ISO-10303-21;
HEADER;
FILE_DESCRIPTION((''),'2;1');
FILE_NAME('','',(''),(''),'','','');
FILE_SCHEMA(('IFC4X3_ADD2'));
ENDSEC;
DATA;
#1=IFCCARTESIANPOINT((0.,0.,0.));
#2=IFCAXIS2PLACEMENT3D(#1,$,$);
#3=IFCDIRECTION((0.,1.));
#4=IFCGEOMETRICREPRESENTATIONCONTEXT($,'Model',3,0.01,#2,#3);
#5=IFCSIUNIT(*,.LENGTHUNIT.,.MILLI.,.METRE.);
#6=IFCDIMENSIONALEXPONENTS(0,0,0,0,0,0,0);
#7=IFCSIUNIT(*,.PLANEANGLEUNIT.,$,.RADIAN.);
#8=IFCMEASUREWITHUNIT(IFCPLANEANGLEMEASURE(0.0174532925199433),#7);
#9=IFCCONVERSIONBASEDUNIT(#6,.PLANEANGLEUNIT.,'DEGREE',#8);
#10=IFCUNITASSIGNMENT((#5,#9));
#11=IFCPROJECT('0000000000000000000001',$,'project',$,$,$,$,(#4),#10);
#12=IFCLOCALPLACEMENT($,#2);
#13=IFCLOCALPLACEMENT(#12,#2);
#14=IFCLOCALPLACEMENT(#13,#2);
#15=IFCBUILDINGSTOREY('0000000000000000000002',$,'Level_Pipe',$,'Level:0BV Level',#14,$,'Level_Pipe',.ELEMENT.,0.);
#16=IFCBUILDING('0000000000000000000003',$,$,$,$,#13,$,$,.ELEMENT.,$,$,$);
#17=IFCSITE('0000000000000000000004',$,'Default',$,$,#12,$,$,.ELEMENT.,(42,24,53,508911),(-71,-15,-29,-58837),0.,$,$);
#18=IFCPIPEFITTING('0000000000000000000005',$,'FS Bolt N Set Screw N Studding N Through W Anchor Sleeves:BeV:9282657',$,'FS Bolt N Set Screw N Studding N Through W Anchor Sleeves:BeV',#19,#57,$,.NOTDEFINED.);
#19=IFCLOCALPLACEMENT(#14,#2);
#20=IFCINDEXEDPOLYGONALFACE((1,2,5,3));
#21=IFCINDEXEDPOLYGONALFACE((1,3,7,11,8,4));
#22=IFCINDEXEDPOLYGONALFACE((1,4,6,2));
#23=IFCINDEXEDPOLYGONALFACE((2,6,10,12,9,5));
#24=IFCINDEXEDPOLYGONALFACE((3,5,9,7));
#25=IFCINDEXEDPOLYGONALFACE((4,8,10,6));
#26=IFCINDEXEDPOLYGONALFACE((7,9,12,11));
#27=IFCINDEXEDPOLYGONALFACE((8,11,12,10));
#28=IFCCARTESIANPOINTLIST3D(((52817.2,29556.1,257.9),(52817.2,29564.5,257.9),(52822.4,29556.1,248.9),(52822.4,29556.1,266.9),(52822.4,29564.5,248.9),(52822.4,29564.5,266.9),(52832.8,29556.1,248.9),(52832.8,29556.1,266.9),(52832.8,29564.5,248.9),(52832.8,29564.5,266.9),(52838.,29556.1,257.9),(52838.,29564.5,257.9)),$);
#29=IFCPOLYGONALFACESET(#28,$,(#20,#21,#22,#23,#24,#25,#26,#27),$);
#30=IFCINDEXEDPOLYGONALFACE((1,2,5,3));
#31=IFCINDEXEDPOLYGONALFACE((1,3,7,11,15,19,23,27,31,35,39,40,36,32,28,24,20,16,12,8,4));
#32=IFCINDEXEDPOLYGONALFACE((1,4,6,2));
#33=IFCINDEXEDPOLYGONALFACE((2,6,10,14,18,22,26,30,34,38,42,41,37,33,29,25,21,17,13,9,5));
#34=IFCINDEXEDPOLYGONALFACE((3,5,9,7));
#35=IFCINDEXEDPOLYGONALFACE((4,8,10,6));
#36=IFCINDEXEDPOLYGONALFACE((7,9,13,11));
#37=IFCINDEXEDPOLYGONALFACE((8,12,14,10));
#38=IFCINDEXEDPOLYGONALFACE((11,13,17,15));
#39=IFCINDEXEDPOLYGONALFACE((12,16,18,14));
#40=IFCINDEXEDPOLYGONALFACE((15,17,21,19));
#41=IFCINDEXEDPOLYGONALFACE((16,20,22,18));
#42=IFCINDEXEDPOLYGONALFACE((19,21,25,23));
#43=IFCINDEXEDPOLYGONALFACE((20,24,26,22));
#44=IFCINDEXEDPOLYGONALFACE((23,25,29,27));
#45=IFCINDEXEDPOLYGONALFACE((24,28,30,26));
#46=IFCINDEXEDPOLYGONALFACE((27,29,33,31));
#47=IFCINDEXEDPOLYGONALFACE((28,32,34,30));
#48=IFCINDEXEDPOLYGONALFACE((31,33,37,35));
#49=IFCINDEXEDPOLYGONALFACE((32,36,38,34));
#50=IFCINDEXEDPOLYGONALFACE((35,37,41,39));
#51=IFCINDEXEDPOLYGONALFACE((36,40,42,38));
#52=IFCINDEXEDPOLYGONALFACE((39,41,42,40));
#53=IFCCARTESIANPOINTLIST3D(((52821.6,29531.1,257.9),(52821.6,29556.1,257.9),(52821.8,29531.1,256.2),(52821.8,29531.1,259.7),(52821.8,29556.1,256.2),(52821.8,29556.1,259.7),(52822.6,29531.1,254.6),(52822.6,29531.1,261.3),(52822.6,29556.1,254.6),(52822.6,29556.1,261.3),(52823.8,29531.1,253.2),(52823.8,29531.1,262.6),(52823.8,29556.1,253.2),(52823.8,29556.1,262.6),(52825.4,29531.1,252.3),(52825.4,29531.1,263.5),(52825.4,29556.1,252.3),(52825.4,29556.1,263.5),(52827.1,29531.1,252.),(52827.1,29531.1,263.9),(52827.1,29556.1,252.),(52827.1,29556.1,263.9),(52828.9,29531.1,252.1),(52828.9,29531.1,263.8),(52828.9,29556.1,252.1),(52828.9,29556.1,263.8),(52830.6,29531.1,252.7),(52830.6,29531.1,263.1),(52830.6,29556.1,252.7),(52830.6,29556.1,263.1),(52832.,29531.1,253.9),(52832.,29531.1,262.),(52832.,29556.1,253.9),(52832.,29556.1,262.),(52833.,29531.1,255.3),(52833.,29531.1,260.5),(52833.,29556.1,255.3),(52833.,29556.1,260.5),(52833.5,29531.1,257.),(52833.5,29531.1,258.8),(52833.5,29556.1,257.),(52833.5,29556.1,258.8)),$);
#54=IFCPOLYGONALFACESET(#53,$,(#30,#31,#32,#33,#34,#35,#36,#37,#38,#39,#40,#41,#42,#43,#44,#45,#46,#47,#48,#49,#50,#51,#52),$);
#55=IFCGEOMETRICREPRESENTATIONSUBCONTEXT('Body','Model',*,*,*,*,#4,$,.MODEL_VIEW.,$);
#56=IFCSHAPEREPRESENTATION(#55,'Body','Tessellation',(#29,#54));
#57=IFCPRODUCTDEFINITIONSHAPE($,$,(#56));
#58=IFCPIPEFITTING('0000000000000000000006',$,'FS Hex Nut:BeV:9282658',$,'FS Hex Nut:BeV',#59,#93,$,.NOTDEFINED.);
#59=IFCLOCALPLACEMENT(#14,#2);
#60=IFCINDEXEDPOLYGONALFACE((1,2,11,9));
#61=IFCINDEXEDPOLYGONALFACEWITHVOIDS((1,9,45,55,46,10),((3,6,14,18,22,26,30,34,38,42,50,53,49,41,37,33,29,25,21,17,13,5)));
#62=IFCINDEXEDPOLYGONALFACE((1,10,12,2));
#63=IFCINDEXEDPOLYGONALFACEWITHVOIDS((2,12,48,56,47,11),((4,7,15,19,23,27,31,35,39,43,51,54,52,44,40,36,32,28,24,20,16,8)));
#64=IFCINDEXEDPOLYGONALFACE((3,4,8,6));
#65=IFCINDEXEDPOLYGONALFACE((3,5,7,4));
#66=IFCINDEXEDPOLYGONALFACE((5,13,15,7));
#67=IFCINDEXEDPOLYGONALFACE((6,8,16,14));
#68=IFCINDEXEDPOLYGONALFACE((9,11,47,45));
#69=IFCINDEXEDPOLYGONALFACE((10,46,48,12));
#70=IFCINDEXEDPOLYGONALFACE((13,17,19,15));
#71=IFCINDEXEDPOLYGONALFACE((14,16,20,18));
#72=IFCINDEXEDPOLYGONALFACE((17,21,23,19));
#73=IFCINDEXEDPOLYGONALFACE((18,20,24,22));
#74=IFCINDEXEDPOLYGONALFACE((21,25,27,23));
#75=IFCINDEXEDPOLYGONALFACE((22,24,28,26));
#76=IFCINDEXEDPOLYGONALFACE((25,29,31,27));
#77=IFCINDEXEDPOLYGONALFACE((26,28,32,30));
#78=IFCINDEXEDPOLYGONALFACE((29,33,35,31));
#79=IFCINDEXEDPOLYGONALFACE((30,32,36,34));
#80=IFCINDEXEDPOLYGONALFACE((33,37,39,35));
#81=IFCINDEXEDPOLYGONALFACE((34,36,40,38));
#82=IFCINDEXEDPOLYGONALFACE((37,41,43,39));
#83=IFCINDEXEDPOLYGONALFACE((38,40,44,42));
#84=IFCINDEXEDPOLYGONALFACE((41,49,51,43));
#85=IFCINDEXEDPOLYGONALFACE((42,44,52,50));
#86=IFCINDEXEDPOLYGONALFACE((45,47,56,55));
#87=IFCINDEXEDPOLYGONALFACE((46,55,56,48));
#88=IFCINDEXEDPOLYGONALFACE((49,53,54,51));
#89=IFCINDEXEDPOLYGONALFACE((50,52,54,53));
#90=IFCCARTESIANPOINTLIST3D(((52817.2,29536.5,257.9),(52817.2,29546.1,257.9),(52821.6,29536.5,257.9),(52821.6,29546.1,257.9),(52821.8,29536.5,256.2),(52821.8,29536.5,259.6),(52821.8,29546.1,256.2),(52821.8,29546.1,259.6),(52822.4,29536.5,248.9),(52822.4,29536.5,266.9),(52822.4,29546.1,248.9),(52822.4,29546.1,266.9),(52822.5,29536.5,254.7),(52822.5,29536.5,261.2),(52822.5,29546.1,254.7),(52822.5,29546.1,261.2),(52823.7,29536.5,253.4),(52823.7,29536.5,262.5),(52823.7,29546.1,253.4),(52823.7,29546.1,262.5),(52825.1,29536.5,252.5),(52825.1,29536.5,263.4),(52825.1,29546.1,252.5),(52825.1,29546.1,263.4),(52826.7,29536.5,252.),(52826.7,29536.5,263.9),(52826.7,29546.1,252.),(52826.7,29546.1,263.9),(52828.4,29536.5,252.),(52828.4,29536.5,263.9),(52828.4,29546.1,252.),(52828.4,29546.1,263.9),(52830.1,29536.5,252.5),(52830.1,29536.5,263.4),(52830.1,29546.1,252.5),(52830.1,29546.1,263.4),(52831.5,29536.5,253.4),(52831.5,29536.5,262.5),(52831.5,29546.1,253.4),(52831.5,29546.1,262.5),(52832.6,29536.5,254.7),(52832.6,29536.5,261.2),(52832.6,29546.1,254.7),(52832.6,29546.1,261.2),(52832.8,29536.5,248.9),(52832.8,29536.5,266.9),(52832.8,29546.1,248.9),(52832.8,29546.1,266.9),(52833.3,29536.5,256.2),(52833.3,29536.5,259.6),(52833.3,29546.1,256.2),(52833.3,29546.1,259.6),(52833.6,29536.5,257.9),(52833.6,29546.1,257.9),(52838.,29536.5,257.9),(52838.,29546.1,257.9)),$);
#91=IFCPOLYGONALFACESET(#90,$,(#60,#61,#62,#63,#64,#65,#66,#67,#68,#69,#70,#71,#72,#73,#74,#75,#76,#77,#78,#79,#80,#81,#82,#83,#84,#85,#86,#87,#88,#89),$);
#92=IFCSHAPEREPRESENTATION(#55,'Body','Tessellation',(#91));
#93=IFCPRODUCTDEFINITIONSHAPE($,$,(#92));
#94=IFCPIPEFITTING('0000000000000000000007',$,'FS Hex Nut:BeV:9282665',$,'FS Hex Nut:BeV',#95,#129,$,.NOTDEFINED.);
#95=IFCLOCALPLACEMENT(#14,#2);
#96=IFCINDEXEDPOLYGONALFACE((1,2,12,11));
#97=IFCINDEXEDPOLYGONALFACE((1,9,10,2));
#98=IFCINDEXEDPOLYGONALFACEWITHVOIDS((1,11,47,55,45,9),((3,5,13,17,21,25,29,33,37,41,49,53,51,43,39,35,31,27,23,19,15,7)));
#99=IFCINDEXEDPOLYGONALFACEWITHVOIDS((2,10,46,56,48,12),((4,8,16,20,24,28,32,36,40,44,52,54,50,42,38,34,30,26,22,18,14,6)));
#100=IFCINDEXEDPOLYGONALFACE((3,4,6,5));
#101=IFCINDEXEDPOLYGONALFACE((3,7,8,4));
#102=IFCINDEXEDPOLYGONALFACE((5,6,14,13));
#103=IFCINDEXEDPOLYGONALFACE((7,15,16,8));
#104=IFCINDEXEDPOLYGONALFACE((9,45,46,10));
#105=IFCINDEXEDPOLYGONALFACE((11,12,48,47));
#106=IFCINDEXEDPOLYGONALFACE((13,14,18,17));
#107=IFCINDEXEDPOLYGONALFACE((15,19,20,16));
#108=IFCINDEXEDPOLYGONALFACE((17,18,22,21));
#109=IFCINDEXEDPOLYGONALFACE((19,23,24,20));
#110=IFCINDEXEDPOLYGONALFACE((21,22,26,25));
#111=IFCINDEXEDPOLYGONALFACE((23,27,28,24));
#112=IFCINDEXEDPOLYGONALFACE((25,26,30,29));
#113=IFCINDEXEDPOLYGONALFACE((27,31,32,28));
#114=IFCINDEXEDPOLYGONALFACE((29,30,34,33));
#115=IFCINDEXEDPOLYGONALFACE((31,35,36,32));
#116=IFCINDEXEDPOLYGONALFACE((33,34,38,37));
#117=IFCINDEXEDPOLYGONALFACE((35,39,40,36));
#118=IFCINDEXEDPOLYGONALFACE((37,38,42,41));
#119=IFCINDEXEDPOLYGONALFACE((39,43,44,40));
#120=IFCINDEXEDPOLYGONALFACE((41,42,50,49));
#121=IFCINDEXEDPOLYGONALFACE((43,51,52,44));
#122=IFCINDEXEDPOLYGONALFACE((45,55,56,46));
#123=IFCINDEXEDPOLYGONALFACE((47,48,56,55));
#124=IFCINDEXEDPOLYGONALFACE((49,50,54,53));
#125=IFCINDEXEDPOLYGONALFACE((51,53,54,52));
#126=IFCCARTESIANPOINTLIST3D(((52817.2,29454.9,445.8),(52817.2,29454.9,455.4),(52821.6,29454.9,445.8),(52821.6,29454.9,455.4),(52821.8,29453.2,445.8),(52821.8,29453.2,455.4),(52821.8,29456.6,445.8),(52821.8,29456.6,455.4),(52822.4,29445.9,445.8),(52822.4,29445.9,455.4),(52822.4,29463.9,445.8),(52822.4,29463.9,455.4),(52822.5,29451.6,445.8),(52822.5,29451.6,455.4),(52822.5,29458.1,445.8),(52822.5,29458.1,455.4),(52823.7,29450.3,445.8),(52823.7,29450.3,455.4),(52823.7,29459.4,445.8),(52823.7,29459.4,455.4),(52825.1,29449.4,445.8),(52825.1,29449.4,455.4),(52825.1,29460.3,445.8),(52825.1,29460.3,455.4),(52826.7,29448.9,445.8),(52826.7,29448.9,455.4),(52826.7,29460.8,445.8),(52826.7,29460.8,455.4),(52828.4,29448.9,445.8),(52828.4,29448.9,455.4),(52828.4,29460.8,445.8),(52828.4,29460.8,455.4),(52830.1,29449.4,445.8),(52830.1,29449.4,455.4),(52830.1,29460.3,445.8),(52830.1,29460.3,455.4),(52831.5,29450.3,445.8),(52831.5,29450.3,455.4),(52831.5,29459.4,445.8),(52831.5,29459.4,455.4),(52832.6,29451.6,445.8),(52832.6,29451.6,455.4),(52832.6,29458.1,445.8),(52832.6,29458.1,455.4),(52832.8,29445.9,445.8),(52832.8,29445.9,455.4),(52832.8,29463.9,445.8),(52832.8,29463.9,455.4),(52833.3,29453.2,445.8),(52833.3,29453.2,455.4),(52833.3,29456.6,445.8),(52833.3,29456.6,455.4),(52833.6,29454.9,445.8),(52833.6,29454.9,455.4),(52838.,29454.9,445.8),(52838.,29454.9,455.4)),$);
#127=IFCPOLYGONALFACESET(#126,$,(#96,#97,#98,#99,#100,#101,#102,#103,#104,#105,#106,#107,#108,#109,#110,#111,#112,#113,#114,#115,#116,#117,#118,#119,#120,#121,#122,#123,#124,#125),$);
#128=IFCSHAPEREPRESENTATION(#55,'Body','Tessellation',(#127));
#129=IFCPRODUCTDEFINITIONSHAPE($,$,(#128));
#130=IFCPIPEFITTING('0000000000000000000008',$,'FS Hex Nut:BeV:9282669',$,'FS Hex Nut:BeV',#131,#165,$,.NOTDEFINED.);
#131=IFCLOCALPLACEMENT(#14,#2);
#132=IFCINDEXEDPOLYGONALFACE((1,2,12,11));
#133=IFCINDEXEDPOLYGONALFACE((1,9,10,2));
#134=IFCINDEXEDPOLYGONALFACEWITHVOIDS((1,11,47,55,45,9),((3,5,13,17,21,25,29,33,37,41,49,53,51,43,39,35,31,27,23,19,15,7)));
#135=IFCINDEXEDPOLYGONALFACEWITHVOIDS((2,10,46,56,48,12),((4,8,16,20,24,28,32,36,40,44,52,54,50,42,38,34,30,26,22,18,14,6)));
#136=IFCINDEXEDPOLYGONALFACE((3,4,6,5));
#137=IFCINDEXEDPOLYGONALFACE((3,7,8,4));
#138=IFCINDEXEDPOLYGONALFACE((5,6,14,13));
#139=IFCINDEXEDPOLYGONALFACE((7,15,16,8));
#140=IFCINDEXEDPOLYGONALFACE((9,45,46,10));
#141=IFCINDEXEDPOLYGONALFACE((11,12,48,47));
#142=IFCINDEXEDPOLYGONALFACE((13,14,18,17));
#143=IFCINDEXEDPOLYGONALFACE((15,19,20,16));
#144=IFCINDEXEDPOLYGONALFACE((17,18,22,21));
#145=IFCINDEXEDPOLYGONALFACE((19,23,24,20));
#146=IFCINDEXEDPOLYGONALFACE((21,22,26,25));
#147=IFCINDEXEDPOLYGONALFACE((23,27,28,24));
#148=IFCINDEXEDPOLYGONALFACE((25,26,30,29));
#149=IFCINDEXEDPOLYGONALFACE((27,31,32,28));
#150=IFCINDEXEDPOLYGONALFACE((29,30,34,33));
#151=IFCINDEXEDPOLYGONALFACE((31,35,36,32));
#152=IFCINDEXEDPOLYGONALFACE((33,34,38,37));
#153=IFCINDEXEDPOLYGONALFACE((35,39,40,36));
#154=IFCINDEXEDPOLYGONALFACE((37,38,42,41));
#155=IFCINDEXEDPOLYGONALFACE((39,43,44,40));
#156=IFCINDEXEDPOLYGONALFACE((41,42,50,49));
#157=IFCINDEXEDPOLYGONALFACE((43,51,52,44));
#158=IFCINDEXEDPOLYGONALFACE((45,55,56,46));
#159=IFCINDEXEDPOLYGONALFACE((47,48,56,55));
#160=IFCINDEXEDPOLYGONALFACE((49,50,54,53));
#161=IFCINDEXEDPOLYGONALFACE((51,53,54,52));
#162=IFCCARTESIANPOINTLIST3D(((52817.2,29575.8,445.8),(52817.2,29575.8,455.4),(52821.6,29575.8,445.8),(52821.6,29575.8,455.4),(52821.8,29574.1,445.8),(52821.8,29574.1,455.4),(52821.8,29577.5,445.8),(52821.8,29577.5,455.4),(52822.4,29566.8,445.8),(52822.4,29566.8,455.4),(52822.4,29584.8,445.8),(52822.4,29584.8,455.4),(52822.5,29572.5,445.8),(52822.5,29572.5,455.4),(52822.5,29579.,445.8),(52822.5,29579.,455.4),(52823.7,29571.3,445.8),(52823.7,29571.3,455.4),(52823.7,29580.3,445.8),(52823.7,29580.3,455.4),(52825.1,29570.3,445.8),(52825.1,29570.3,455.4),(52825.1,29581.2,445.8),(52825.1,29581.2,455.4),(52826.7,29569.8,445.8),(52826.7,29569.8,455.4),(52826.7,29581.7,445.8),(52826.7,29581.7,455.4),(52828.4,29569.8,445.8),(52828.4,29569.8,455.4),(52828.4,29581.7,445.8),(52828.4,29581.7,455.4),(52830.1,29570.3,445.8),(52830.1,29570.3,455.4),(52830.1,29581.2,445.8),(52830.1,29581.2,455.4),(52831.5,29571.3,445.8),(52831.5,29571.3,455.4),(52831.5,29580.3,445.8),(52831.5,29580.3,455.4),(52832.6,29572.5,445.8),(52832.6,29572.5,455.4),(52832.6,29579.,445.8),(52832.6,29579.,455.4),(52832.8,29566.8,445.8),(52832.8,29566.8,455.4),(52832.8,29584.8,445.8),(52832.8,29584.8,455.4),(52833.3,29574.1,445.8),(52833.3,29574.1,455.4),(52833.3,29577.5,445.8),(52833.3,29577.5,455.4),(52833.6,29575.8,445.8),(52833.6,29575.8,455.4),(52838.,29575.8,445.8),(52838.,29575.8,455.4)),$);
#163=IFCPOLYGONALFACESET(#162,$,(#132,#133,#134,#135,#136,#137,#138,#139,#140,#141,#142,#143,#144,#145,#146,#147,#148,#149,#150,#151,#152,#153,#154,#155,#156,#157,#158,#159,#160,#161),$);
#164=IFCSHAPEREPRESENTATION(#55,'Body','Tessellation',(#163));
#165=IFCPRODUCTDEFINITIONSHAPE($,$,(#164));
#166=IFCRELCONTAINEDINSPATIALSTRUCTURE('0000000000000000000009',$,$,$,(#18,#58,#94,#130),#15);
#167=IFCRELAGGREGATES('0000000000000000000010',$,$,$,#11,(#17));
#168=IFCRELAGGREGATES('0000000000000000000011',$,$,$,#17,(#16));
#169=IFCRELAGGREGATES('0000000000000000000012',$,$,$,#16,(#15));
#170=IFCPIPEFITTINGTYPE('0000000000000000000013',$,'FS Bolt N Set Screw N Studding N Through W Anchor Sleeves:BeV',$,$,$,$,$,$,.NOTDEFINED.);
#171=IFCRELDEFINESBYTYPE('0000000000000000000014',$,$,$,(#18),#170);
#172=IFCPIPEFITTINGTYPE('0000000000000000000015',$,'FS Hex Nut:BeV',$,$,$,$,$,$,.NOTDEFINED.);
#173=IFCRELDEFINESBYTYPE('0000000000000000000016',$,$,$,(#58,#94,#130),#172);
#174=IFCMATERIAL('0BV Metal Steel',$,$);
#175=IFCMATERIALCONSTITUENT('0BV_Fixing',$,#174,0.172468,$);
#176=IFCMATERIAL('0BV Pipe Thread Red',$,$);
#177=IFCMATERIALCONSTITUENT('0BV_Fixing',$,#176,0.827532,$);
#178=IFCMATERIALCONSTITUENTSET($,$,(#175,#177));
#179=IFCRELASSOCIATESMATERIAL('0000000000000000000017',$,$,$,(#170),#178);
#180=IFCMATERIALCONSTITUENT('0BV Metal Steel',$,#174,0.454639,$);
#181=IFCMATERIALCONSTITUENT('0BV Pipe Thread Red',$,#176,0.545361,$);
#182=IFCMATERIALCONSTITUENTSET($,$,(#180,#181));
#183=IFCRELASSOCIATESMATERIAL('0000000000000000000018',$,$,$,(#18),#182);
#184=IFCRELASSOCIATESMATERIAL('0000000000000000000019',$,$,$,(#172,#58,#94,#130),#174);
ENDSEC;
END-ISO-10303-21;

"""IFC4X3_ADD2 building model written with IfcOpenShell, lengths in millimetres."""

from ifc_helpers import new_model, entity, si_unit, converted_unit, direction, frame, frame_2d, origin, origin_2d_with_axis, place, context, subcontext, project, spatial, polyline, circle_curve, parameter, trimmed, segment, composite_curve, circle, outline, extrude, source, transform, mapped, material, constituent, constituent_set, type_object, type_shapes, element, save


model = new_model("IFC4X3_ADD2")

# Units and contexts
model_context = context("Model", 3, precision=0.01, world=origin(), true_north=direction((0.0, 1.0)))
body_context = subcontext(model_context, "Body", "Model", "MODEL_VIEW")
ifc_project = project(units=[si_unit("LENGTHUNIT", "METRE", prefix="MILLI"), converted_unit("PLANEANGLEUNIT", "DEGREE", entity("IfcPlaneAngleMeasure", 0.0174532925199433), si_unit("PLANEANGLEUNIT", "RADIAN"), dimensions=[0, 0, 0, 0, 0, 0, 0])], contexts=[model_context])

# Site, building, storey
site_placement = place(None, origin())
site = spatial("IfcSite", under=ifc_project, at=site_placement, Name="Default", CompositionType="ELEMENT", RefLatitude=(42, 24, 53, 508911), RefLongitude=(-71, -15, -29, -58837), RefElevation=0.0)
building_placement = place(site_placement, origin())
building = spatial("IfcBuilding", under=site, at=building_placement, CompositionType="ELEMENT")
storey_placement = place(building_placement, origin())
storey = spatial("IfcBuildingStorey", under=building, at=storey_placement, Name="Level_Pipe", ObjectType="Level:0BV Level", LongName="Level_Pipe", CompositionType="ELEMENT", Elevation=0.0)

# Pipe fittings
ifc_material_1 = material(Name="0BV Metal Steel")
ifc_constituent_1 = constituent(ifc_material_1, Name="0BV Metal Steel", fraction=0.454639)
ifc_material_2 = material(Name="0BV Pipe Thread Red")
ifc_constituent_2 = constituent(ifc_material_2, Name="0BV Pipe Thread Red", fraction=0.545361)
ifc_constituent_set_1 = constituent_set(constituents=[ifc_constituent_1, ifc_constituent_2])
ifc_constituent_3 = constituent(ifc_material_1, Name="0BV_Fixing", fraction=0.172468)
ifc_constituent_4 = constituent(ifc_material_2, Name="0BV_Fixing", fraction=0.827532)
ifc_constituent_set_2 = constituent_set(constituents=[ifc_constituent_3, ifc_constituent_4])
pipe_fitting_type_1 = type_object("IfcPipeFittingType", Name="FS Bolt N Set Screw N Studding N Through W Anchor Sleeves:BeV", PredefinedType="NOTDEFINED", material=ifc_constituent_set_2)
shared_shape_1 = source(origin(), body_context, "Body", "SweptSolid", [
    extrude(outline(polyline([(-5.2, -9.0), (5.2, -9.0), (10.4, 0.0), (5.2, 9.0), (-5.2, 9.0), (-10.4, 0.0), (-5.2, -9.0)])), frame((-8.4, 0.0, 0.0), z_axis=(1.0, 0.0, 0.0), x_axis=(0.0, -1.0, 0.0)), (0.0, 0.0, 1.0), 8.4),
    extrude(circle(Radius=6.0, at=frame_2d((0.0, 0.0), x_axis=(1.0, 0.0))), frame((0.0, 0.0, 0.0), z_axis=(1.0, 0.0, 0.0), x_axis=(0.0, -1.0, 0.0)), (0.0, 0.0, 1.0), 25.0),
])
type_shapes(pipe_fitting_type_1, [shared_shape_1])
pipe_fitting_1_placement = place(storey_placement, frame((52827.6, 29556.1, 257.9), z_axis=(0.0, 0.0, 1.0), x_axis=(0.0, -1.0, 0.0)))
element("IfcPipeFitting", 1, at=pipe_fitting_1_placement, inside=storey, type_object=pipe_fitting_type_1, material=ifc_constituent_set_1, Name="FS Bolt N Set Screw N Studding N Through W Anchor Sleeves:BeV:9282657", ObjectType="FS Bolt N Set Screw N Studding N Through W Anchor Sleeves:BeV", PredefinedType="NOTDEFINED", context=body_context, shape_type="MappedRepresentation", body=[
    mapped(shared_shape_1, transform((0.0, 0.0, 0.0), scale=1.0)),
])
pipe_fitting_type_2 = type_object("IfcPipeFittingType", Name="FS Hex Nut:BeV", PredefinedType="NOTDEFINED", material=ifc_material_1)
shared_shape_2 = source(origin(), body_context, "Body", "SweptSolid", [
    extrude(outline(polyline([(-5.2, -9.0), (5.2, -9.0), (10.4, 0.0), (5.2, 9.0), (-5.2, 9.0), (-10.4, 0.0), (-5.2, -9.0)]), holes=[composite_curve([segment(trimmed(circle_curve(origin_2d_with_axis(), 6.0), [parameter(0.0)], [parameter(180.0)], True, "PARAMETER"), False, "CONTINUOUS"), segment(trimmed(circle_curve(origin_2d_with_axis(), 6.0), [parameter(180.0)], [parameter(0.0)], True, "PARAMETER"), False, "CONTINUOUS")], self_intersect=False)]), frame((0.0, 10.4, 9.0), z_axis=(1.0, 0.0, 0.0), x_axis=(0.0, -1.0, 0.0)), (0.0, 0.0, 1.0), 9.6),
])
type_shapes(pipe_fitting_type_2, [shared_shape_2])
for number, where, z_axis, x_axis, name in (
    (2, (52817.2, 29546.1, 248.9), (0.0, 0.0, 1.0), (0.0, -1.0, 0.0), "FS Hex Nut:BeV:9282658"),
    (3, (52817.2, 29463.9, 455.4), (0.0, -1.0, 0.0), (0.0, 0.0, -1.0), "FS Hex Nut:BeV:9282665"),
    (4, (52817.2, 29584.8, 455.4), (0.0, -1.0, 0.0), (0.0, 0.0, -1.0), "FS Hex Nut:BeV:9282669"),
):
    element("IfcPipeFitting", number, at=place(storey_placement, frame(where, z_axis=z_axis, x_axis=x_axis)), inside=storey, type_object=pipe_fitting_type_2, material=ifc_material_1, Name=name, ObjectType="FS Hex Nut:BeV", PredefinedType="NOTDEFINED", context=body_context, shape_type="MappedRepresentation", body=[
        mapped(shared_shape_2, transform((0.0, 0.0, 0.0), scale=1.0)),
    ])

save(model, "model.ifc")
